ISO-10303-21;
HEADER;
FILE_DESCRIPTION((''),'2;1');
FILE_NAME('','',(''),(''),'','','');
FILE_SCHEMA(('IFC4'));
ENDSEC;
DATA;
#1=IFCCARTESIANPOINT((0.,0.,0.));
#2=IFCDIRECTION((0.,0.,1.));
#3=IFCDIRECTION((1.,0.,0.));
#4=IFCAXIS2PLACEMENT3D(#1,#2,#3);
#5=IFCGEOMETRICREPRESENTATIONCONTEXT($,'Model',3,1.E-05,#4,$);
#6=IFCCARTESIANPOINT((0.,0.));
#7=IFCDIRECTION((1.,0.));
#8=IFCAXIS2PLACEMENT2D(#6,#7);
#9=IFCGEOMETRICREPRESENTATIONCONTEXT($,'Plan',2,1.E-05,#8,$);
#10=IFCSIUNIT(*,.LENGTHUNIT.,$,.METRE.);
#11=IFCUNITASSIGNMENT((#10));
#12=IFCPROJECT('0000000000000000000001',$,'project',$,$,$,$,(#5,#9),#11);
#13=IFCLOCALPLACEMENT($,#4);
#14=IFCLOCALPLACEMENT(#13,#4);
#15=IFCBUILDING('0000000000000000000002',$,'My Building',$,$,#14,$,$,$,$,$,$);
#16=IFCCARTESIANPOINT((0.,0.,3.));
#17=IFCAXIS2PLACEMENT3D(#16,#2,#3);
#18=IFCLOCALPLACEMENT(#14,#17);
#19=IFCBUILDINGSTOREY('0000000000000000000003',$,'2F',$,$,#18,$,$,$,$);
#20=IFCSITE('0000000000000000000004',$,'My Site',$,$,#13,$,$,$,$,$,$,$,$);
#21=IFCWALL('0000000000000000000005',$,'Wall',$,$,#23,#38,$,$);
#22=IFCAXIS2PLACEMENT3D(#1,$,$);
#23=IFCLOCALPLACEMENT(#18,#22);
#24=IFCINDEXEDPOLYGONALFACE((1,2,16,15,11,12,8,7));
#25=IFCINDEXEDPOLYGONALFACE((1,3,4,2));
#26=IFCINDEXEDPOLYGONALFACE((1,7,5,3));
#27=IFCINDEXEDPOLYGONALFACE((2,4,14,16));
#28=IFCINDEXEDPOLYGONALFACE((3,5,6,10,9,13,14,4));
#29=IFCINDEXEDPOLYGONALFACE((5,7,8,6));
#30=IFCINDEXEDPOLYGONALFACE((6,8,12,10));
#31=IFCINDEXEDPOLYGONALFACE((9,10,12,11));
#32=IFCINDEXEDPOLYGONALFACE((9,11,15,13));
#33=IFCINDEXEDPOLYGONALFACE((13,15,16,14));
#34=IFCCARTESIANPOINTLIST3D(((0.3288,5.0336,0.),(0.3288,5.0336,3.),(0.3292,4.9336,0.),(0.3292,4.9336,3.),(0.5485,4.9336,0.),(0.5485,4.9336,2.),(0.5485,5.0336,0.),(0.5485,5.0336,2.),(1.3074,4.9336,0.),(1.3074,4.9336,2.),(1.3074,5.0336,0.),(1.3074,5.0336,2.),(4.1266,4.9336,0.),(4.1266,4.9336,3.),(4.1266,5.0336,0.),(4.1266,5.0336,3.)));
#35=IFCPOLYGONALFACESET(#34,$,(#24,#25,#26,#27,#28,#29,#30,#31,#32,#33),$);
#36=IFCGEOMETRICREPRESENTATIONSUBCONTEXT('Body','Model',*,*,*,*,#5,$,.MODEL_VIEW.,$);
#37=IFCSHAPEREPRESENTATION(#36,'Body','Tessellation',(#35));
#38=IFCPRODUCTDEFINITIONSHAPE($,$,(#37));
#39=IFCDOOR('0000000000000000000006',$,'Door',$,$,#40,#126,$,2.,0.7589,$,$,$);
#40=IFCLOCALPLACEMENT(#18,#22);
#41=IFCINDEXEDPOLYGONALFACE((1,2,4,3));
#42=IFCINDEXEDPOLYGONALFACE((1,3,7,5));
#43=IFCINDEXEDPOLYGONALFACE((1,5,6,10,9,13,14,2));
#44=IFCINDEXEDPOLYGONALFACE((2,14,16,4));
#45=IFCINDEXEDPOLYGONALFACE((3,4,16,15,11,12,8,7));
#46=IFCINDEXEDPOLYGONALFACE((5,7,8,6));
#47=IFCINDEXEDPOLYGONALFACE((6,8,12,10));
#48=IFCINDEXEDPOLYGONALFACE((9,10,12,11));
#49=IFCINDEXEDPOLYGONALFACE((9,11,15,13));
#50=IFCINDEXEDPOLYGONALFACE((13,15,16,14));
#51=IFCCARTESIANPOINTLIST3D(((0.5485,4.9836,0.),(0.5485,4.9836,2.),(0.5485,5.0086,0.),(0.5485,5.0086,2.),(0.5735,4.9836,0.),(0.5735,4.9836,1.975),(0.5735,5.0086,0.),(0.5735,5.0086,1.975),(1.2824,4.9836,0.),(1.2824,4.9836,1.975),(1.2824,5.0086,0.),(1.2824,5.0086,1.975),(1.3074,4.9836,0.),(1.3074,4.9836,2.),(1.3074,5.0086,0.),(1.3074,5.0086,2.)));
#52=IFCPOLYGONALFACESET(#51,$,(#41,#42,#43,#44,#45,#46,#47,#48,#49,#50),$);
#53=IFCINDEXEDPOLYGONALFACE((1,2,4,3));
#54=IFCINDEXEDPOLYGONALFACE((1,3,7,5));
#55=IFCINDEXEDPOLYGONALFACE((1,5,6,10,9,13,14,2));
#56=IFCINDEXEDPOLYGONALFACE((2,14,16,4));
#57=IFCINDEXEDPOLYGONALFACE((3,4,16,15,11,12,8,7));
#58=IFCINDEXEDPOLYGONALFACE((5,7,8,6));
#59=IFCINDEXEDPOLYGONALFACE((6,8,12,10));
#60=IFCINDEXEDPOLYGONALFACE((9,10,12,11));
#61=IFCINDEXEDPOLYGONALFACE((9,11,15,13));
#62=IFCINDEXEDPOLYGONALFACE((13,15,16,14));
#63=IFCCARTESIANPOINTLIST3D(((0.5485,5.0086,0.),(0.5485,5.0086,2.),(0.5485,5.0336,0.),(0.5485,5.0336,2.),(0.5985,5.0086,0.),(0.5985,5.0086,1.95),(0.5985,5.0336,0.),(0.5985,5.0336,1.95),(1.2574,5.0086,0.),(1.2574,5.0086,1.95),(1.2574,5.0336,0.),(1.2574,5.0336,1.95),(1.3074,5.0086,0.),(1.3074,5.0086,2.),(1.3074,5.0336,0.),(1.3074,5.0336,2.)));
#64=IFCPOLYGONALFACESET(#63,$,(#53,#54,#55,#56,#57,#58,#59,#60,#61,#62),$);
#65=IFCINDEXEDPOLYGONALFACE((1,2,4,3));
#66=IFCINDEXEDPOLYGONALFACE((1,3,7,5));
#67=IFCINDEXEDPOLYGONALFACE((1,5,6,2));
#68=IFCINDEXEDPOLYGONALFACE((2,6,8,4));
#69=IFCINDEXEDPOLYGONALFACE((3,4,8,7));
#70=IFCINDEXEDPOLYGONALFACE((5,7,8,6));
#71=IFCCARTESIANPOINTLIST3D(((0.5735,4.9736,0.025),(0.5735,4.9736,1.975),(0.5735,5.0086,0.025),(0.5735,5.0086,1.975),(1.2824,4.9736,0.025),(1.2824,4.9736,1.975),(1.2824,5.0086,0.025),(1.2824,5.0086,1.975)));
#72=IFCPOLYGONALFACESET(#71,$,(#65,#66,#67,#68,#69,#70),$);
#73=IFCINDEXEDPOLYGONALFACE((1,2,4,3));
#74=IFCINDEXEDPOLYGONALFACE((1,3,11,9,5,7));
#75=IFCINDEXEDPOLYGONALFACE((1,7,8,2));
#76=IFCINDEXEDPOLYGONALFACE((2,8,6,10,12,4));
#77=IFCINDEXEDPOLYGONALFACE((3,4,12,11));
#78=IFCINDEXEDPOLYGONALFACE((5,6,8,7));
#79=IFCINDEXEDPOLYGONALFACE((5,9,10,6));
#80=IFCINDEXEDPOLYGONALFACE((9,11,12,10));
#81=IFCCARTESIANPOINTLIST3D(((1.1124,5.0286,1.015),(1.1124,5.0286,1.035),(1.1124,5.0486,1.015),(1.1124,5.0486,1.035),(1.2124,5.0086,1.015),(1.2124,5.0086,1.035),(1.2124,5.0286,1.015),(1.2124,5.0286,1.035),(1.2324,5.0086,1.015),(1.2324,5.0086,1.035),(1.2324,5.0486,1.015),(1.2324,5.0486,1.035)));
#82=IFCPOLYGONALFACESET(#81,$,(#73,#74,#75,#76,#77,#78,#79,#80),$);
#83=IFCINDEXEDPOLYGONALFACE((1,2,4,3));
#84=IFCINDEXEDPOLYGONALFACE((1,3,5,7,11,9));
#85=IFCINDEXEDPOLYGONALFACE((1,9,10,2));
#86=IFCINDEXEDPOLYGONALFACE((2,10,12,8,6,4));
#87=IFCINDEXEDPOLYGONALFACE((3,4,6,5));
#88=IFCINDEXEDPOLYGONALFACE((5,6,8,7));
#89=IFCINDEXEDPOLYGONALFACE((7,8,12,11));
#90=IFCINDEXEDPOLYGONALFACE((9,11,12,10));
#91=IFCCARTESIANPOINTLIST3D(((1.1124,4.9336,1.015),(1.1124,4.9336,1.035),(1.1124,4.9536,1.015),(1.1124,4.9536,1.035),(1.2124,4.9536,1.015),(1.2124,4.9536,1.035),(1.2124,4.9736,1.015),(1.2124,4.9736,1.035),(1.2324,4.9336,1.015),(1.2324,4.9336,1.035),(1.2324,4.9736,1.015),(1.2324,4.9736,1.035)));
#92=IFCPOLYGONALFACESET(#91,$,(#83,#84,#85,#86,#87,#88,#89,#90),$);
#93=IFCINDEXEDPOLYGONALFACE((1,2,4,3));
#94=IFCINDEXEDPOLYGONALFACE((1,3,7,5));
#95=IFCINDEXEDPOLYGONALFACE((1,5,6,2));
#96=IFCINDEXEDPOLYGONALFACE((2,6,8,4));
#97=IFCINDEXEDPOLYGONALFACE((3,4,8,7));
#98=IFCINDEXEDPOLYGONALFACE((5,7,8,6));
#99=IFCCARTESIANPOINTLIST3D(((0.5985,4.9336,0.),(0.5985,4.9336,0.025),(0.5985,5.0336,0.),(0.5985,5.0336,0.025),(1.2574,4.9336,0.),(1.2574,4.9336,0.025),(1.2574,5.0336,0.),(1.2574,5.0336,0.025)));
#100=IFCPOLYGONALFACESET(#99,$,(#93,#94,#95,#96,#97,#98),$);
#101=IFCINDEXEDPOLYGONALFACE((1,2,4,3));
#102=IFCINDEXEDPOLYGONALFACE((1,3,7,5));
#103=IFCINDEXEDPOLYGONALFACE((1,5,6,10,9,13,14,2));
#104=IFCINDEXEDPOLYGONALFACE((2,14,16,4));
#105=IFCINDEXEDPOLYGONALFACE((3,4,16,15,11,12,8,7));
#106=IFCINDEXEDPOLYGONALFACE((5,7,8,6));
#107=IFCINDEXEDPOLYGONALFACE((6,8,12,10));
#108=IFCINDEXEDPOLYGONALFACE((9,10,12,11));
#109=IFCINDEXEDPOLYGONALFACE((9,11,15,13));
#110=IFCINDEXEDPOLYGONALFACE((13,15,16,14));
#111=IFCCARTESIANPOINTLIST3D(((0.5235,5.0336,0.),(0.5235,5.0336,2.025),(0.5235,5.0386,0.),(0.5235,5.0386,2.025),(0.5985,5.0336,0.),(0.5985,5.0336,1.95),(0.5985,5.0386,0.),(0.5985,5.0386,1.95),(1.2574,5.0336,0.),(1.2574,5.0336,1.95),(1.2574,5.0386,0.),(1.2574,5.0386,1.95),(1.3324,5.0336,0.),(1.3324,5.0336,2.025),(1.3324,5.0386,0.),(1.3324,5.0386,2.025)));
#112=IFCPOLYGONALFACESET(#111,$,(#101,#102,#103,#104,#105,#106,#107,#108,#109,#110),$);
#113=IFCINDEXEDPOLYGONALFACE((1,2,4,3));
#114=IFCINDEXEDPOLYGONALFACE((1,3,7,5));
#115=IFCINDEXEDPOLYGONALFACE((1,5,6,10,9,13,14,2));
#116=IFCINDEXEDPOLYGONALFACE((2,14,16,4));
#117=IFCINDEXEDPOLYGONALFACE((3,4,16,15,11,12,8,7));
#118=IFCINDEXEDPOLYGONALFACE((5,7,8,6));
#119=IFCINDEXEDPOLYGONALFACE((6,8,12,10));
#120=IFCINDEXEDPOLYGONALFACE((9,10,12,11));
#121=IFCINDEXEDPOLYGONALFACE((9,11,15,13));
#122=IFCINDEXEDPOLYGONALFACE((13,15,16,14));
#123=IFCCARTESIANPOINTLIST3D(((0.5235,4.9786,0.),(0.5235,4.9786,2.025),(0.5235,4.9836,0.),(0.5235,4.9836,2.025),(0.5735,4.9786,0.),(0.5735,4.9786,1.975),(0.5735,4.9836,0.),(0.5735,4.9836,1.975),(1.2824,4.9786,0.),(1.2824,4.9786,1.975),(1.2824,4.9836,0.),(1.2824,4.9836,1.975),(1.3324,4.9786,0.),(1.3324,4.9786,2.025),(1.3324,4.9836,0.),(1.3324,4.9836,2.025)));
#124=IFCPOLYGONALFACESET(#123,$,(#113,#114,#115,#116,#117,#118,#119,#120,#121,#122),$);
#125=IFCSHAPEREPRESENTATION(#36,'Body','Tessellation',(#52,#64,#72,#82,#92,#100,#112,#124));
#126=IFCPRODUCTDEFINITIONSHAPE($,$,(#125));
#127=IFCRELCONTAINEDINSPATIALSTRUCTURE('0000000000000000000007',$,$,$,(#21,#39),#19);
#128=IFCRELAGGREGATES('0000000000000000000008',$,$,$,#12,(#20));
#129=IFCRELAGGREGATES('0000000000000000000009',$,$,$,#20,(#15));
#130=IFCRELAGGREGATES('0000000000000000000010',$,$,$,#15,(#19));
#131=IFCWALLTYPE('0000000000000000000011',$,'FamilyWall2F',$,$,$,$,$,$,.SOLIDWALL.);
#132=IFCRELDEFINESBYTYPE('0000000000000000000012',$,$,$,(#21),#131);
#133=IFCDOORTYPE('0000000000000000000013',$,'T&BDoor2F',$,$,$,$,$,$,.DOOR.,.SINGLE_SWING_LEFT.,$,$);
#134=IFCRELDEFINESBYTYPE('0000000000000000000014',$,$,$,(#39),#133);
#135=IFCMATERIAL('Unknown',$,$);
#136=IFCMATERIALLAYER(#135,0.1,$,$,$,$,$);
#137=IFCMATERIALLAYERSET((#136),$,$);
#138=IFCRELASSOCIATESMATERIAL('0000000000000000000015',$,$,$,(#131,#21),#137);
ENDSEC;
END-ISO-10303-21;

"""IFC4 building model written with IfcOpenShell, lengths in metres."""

from ifc_helpers import new_model, entity, si_unit, frame, origin_with_axes, origin_2d_with_axis, place, context, subcontext, project, spatial, line, indexed_curve, outline, extrude, shape, source, transform, mapped, material, layer, layer_set, layer_usage, type_object, type_shapes, element, fill, save


model = new_model("IFC4")

# Units and contexts
model_context = context("Model", 3, precision=1e-05, world=origin_with_axes())
plan_context = context("Plan", 2, precision=1e-05, world=origin_2d_with_axis())
body_context_1 = subcontext(model_context, "Body", "Model", "MODEL_VIEW")
body_context_2 = subcontext(plan_context, "Body", "Plan", "PLAN_VIEW")
ifc_project = project(units=[si_unit("LENGTHUNIT", "METRE")], contexts=[model_context, plan_context])

# Site, building, storey
site_placement = place(None, origin_with_axes())
site = spatial("IfcSite", under=ifc_project, at=site_placement, Name="My Site")
building_placement = place(site_placement, origin_with_axes())
building = spatial("IfcBuilding", under=site, at=building_placement, Name="My Building")
storey_placement = place(building_placement, frame((0.0, 0.0, 3.0), z_axis=(0.0, 0.0, 1.0), x_axis=(1.0, 0.0, 0.0)))
storey = spatial("IfcBuildingStorey", under=building, at=storey_placement, Name="2F")

# Shared definitions
ifc_material = material(Name="Unknown")

# Wall, opening, door
ifc_layer_1 = layer(ifc_material, 0.1)
ifc_layer_set_1 = layer_set([ifc_layer_1])
ifc_layer_usage_1 = layer_usage(ifc_layer_set_1, "AXIS2", "POSITIVE", 0.0)
wall_type_1 = type_object("IfcWallType", Name="FamilyWall2F", PredefinedType="SOLIDWALL", material=ifc_layer_set_1)
wall_1_placement = place(storey_placement, frame((4.2266, 5.0336, 0.0), z_axis=(0.0, 0.0, 1.0), x_axis=(-1.0, 0.0, 0.0)))
wall_1 = element("IfcWall", 1, at=wall_1_placement, inside=storey, type_object=wall_type_1, material=ifc_layer_usage_1, Name="Wall", context=body_context_1, shape_type="SweptSolid", body=[
    extrude(outline(indexed_curve([(0.1, 0.0), (0.1, 0.1), (3.8974, 0.1), (3.8978, 0.0)], segments=[line(1, 2, 3, 4, 1)])), origin_with_axes(), (0.0, 0.0, 1.0), 3.0),
])
shared_shape_1 = source(origin_with_axes(), body_context_1, "Body", "SweptSolid", [
    extrude(outline(indexed_curve([(0.0, 0.0), (0.7589, 0.0), (0.7589, 2.0), (0.0, 2.0)], segments=[line(1, 2, 3, 4, 1)])), frame((0.0, -0.6, 0.0), z_axis=(0.0, -1.0, 0.0), x_axis=(1.0, 0.0, 0.0)), (0.0, 0.0, -1.0), 1.2),
])
opening_1_placement = place(wall_1_placement, frame((2.9192, 0.0, 0.0), z_axis=(0.0, 0.0, 1.0), x_axis=(1.0, 0.0, 0.0)))
opening_1 = element("IfcOpeningElement", 2, at=opening_1_placement, cuts=wall_1, PredefinedType="OPENING", context=body_context_1, shape_type="MappedRepresentation", body=[
    mapped(shared_shape_1, transform((0.0, 0.0, 0.0), x_axis=(1.0, 0.0, 0.0), y_axis=(0.0, 1.0, 0.0), z_axis=(0.0, 0.0, 1.0), scale=1.0)),
])
door_type = type_object("IfcDoorType", Name="T&BDoor2F", OperationType="SINGLE_SWING_LEFT", PredefinedType="DOOR")
shared_shape_2 = source(origin_with_axes(), body_context_1, "Body", "SweptSolid", [
    extrude(outline(indexed_curve([(0.0, 0.0), (0.0, 2.0), (0.7589, 2.0), (0.7589, 0.0), (0.7339, 0.0), (0.7339, 1.975), (0.025, 1.975), (0.025, 0.0)], segments=[line(1, 2, 3, 4, 5, 6, 7, 8, 1)])), frame((0.0, 0.025, 0.0), z_axis=(0.0, -1.0, 0.0), x_axis=(1.0, 0.0, 0.0)), (0.0, 0.0, -1.0), 0.025),
    extrude(outline(indexed_curve([(0.0, 0.0), (0.0, 2.0), (0.7589, 2.0), (0.7589, 0.0), (0.7089, 0.0), (0.7089, 1.95), (0.05, 1.95), (0.05, 0.0)], segments=[line(1, 2, 3, 4, 5, 6, 7, 8, 1)])), frame((0.0, 0.0, 0.0), z_axis=(0.0, -1.0, 0.0), x_axis=(1.0, 0.0, 0.0)), (0.0, 0.0, -1.0), 0.025),
    extrude(outline(indexed_curve([(0.0, 0.0), (0.7089, 0.0), (0.7089, 0.035), (0.0, 0.035)], segments=[line(1, 2, 3, 4, 1)])), frame((0.025, 0.025, 0.025), z_axis=(0.0, 0.0, 1.0), x_axis=(1.0, 0.0, 0.0)), (0.0, 0.0, 1.0), 1.95),
    extrude(outline(indexed_curve([(0.0, 0.0), (0.0, -0.04), (0.12, -0.04), (0.12, -0.02), (0.02, -0.02), (0.02, 0.0)], segments=[line(1, 2, 3, 4, 5, 6, 1)])), frame((0.075, 0.025, 1.015), z_axis=(0.0, 0.0, 1.0), x_axis=(1.0, 0.0, 0.0)), (0.0, 0.0, 1.0), 0.02),
    extrude(outline(indexed_curve([(0.0, 0.0), (0.0, 0.04), (0.12, 0.04), (0.12, 0.02), (0.02, 0.02), (0.02, 0.0)], segments=[line(1, 2, 3, 4, 5, 6, 1)])), frame((0.075, 0.06, 1.015), z_axis=(0.0, 0.0, 1.0), x_axis=(1.0, 0.0, 0.0)), (0.0, 0.0, 1.0), 0.02),
    extrude(outline(indexed_curve([(0.0, 0.0), (0.6589, 0.0), (0.6589, 0.1), (0.0, 0.1)], segments=[line(1, 2, 3, 4, 1)])), frame((0.05, 0.0, 0.0), z_axis=(0.0, 0.0, 1.0), x_axis=(1.0, 0.0, 0.0)), (0.0, 0.0, 1.0), 0.025),
    extrude(outline(indexed_curve([(0.0, 0.0), (0.0, 2.025), (0.8089, 2.025), (0.8089, 0.0), (0.7339, 0.0), (0.7339, 1.95), (0.075, 1.95), (0.075, 0.0)], segments=[line(1, 2, 3, 4, 5, 6, 7, 8, 1)])), frame((-0.025, -0.005, 0.0), z_axis=(0.0, -1.0, 0.0), x_axis=(1.0, 0.0, 0.0)), (0.0, 0.0, -1.0), 0.005),
    extrude(outline(indexed_curve([(0.0, 0.0), (0.0, 2.025), (0.8089, 2.025), (0.8089, 0.0), (0.7589, 0.0), (0.7589, 1.975), (0.05, 1.975), (0.05, 0.0)], segments=[line(1, 2, 3, 4, 5, 6, 7, 8, 1)])), frame((-0.025, 0.05, 0.0), z_axis=(0.0, -1.0, 0.0), x_axis=(1.0, 0.0, 0.0)), (0.0, 0.0, -1.0), 0.005),
])
shared_shape_3 = source(origin_with_axes(), body_context_2, "Body", "Curve2D", [
    entity("IfcIndexedPolyCurve", entity("IfcCartesianPointList2D", [[0.0, 0.0], [0.0, 0.05], [0.025, 0.05], [0.025, 0.025], [0.05, 0.025], [0.05, 0.0]]), [entity("IfcLineIndex", [1, 2, 3, 4, 5, 6, 1])]),
    entity("IfcIndexedPolyCurve", entity("IfcCartesianPointList2D", [[0.7589, 0.0], [0.7589, 0.05], [0.7339, 0.05], [0.7339, 0.025], [0.7089, 0.025], [0.7089, 0.0]]), [entity("IfcLineIndex", [1, 2, 3, 4, 5, 6, 1])]),
    entity("IfcTrimmedCurve", entity("IfcEllipse", entity("IfcAxis2Placement2D", entity("IfcCartesianPoint", [0.6989, 0.05]), entity("IfcDirection", [1.0, 0.0])), 0.6739, 0.7089), [entity("IfcCartesianPoint", [0.6989, 0.7589])], [entity("IfcCartesianPoint", [0.025, 0.05])], True, "CARTESIAN"),
    entity("IfcIndexedPolyCurve", entity("IfcCartesianPointList2D", [[0.7339, 0.05], [0.6989, 0.05], [0.6989, 0.7589], [0.7339, 0.7589]]), [entity("IfcLineIndex", [1, 2, 3, 4, 1])]),
])
type_shapes(door_type, [shared_shape_2, shared_shape_3])
door_placement = place(opening_1_placement, frame((0.0, 0.0, 0.0), z_axis=(0.0, 0.0, 1.0), x_axis=(1.0, 0.0, 0.0)))
door = element("IfcDoor", 3, at=door_placement, inside=storey, type_object=door_type, Name="Door", OverallHeight=2.0, OverallWidth=0.7589, shapes=[
    shape(body_context_1, "Body", "MappedRepresentation", [mapped(shared_shape_2, transform((0.0, 0.0, 0.0), x_axis=(1.0, 0.0, 0.0), y_axis=(0.0, 1.0, 0.0), z_axis=(0.0, 0.0, 1.0), scale=1.0))]),
    shape(body_context_2, "Body", "MappedRepresentation", [mapped(shared_shape_3, transform((0.0, 0.0, 0.0), x_axis=(1.0, 0.0, 0.0), y_axis=(0.0, 1.0, 0.0), z_axis=(0.0, 0.0, 1.0), scale=1.0))]),
])
fill(opening_1, door)

save(model, "model.ifc")
